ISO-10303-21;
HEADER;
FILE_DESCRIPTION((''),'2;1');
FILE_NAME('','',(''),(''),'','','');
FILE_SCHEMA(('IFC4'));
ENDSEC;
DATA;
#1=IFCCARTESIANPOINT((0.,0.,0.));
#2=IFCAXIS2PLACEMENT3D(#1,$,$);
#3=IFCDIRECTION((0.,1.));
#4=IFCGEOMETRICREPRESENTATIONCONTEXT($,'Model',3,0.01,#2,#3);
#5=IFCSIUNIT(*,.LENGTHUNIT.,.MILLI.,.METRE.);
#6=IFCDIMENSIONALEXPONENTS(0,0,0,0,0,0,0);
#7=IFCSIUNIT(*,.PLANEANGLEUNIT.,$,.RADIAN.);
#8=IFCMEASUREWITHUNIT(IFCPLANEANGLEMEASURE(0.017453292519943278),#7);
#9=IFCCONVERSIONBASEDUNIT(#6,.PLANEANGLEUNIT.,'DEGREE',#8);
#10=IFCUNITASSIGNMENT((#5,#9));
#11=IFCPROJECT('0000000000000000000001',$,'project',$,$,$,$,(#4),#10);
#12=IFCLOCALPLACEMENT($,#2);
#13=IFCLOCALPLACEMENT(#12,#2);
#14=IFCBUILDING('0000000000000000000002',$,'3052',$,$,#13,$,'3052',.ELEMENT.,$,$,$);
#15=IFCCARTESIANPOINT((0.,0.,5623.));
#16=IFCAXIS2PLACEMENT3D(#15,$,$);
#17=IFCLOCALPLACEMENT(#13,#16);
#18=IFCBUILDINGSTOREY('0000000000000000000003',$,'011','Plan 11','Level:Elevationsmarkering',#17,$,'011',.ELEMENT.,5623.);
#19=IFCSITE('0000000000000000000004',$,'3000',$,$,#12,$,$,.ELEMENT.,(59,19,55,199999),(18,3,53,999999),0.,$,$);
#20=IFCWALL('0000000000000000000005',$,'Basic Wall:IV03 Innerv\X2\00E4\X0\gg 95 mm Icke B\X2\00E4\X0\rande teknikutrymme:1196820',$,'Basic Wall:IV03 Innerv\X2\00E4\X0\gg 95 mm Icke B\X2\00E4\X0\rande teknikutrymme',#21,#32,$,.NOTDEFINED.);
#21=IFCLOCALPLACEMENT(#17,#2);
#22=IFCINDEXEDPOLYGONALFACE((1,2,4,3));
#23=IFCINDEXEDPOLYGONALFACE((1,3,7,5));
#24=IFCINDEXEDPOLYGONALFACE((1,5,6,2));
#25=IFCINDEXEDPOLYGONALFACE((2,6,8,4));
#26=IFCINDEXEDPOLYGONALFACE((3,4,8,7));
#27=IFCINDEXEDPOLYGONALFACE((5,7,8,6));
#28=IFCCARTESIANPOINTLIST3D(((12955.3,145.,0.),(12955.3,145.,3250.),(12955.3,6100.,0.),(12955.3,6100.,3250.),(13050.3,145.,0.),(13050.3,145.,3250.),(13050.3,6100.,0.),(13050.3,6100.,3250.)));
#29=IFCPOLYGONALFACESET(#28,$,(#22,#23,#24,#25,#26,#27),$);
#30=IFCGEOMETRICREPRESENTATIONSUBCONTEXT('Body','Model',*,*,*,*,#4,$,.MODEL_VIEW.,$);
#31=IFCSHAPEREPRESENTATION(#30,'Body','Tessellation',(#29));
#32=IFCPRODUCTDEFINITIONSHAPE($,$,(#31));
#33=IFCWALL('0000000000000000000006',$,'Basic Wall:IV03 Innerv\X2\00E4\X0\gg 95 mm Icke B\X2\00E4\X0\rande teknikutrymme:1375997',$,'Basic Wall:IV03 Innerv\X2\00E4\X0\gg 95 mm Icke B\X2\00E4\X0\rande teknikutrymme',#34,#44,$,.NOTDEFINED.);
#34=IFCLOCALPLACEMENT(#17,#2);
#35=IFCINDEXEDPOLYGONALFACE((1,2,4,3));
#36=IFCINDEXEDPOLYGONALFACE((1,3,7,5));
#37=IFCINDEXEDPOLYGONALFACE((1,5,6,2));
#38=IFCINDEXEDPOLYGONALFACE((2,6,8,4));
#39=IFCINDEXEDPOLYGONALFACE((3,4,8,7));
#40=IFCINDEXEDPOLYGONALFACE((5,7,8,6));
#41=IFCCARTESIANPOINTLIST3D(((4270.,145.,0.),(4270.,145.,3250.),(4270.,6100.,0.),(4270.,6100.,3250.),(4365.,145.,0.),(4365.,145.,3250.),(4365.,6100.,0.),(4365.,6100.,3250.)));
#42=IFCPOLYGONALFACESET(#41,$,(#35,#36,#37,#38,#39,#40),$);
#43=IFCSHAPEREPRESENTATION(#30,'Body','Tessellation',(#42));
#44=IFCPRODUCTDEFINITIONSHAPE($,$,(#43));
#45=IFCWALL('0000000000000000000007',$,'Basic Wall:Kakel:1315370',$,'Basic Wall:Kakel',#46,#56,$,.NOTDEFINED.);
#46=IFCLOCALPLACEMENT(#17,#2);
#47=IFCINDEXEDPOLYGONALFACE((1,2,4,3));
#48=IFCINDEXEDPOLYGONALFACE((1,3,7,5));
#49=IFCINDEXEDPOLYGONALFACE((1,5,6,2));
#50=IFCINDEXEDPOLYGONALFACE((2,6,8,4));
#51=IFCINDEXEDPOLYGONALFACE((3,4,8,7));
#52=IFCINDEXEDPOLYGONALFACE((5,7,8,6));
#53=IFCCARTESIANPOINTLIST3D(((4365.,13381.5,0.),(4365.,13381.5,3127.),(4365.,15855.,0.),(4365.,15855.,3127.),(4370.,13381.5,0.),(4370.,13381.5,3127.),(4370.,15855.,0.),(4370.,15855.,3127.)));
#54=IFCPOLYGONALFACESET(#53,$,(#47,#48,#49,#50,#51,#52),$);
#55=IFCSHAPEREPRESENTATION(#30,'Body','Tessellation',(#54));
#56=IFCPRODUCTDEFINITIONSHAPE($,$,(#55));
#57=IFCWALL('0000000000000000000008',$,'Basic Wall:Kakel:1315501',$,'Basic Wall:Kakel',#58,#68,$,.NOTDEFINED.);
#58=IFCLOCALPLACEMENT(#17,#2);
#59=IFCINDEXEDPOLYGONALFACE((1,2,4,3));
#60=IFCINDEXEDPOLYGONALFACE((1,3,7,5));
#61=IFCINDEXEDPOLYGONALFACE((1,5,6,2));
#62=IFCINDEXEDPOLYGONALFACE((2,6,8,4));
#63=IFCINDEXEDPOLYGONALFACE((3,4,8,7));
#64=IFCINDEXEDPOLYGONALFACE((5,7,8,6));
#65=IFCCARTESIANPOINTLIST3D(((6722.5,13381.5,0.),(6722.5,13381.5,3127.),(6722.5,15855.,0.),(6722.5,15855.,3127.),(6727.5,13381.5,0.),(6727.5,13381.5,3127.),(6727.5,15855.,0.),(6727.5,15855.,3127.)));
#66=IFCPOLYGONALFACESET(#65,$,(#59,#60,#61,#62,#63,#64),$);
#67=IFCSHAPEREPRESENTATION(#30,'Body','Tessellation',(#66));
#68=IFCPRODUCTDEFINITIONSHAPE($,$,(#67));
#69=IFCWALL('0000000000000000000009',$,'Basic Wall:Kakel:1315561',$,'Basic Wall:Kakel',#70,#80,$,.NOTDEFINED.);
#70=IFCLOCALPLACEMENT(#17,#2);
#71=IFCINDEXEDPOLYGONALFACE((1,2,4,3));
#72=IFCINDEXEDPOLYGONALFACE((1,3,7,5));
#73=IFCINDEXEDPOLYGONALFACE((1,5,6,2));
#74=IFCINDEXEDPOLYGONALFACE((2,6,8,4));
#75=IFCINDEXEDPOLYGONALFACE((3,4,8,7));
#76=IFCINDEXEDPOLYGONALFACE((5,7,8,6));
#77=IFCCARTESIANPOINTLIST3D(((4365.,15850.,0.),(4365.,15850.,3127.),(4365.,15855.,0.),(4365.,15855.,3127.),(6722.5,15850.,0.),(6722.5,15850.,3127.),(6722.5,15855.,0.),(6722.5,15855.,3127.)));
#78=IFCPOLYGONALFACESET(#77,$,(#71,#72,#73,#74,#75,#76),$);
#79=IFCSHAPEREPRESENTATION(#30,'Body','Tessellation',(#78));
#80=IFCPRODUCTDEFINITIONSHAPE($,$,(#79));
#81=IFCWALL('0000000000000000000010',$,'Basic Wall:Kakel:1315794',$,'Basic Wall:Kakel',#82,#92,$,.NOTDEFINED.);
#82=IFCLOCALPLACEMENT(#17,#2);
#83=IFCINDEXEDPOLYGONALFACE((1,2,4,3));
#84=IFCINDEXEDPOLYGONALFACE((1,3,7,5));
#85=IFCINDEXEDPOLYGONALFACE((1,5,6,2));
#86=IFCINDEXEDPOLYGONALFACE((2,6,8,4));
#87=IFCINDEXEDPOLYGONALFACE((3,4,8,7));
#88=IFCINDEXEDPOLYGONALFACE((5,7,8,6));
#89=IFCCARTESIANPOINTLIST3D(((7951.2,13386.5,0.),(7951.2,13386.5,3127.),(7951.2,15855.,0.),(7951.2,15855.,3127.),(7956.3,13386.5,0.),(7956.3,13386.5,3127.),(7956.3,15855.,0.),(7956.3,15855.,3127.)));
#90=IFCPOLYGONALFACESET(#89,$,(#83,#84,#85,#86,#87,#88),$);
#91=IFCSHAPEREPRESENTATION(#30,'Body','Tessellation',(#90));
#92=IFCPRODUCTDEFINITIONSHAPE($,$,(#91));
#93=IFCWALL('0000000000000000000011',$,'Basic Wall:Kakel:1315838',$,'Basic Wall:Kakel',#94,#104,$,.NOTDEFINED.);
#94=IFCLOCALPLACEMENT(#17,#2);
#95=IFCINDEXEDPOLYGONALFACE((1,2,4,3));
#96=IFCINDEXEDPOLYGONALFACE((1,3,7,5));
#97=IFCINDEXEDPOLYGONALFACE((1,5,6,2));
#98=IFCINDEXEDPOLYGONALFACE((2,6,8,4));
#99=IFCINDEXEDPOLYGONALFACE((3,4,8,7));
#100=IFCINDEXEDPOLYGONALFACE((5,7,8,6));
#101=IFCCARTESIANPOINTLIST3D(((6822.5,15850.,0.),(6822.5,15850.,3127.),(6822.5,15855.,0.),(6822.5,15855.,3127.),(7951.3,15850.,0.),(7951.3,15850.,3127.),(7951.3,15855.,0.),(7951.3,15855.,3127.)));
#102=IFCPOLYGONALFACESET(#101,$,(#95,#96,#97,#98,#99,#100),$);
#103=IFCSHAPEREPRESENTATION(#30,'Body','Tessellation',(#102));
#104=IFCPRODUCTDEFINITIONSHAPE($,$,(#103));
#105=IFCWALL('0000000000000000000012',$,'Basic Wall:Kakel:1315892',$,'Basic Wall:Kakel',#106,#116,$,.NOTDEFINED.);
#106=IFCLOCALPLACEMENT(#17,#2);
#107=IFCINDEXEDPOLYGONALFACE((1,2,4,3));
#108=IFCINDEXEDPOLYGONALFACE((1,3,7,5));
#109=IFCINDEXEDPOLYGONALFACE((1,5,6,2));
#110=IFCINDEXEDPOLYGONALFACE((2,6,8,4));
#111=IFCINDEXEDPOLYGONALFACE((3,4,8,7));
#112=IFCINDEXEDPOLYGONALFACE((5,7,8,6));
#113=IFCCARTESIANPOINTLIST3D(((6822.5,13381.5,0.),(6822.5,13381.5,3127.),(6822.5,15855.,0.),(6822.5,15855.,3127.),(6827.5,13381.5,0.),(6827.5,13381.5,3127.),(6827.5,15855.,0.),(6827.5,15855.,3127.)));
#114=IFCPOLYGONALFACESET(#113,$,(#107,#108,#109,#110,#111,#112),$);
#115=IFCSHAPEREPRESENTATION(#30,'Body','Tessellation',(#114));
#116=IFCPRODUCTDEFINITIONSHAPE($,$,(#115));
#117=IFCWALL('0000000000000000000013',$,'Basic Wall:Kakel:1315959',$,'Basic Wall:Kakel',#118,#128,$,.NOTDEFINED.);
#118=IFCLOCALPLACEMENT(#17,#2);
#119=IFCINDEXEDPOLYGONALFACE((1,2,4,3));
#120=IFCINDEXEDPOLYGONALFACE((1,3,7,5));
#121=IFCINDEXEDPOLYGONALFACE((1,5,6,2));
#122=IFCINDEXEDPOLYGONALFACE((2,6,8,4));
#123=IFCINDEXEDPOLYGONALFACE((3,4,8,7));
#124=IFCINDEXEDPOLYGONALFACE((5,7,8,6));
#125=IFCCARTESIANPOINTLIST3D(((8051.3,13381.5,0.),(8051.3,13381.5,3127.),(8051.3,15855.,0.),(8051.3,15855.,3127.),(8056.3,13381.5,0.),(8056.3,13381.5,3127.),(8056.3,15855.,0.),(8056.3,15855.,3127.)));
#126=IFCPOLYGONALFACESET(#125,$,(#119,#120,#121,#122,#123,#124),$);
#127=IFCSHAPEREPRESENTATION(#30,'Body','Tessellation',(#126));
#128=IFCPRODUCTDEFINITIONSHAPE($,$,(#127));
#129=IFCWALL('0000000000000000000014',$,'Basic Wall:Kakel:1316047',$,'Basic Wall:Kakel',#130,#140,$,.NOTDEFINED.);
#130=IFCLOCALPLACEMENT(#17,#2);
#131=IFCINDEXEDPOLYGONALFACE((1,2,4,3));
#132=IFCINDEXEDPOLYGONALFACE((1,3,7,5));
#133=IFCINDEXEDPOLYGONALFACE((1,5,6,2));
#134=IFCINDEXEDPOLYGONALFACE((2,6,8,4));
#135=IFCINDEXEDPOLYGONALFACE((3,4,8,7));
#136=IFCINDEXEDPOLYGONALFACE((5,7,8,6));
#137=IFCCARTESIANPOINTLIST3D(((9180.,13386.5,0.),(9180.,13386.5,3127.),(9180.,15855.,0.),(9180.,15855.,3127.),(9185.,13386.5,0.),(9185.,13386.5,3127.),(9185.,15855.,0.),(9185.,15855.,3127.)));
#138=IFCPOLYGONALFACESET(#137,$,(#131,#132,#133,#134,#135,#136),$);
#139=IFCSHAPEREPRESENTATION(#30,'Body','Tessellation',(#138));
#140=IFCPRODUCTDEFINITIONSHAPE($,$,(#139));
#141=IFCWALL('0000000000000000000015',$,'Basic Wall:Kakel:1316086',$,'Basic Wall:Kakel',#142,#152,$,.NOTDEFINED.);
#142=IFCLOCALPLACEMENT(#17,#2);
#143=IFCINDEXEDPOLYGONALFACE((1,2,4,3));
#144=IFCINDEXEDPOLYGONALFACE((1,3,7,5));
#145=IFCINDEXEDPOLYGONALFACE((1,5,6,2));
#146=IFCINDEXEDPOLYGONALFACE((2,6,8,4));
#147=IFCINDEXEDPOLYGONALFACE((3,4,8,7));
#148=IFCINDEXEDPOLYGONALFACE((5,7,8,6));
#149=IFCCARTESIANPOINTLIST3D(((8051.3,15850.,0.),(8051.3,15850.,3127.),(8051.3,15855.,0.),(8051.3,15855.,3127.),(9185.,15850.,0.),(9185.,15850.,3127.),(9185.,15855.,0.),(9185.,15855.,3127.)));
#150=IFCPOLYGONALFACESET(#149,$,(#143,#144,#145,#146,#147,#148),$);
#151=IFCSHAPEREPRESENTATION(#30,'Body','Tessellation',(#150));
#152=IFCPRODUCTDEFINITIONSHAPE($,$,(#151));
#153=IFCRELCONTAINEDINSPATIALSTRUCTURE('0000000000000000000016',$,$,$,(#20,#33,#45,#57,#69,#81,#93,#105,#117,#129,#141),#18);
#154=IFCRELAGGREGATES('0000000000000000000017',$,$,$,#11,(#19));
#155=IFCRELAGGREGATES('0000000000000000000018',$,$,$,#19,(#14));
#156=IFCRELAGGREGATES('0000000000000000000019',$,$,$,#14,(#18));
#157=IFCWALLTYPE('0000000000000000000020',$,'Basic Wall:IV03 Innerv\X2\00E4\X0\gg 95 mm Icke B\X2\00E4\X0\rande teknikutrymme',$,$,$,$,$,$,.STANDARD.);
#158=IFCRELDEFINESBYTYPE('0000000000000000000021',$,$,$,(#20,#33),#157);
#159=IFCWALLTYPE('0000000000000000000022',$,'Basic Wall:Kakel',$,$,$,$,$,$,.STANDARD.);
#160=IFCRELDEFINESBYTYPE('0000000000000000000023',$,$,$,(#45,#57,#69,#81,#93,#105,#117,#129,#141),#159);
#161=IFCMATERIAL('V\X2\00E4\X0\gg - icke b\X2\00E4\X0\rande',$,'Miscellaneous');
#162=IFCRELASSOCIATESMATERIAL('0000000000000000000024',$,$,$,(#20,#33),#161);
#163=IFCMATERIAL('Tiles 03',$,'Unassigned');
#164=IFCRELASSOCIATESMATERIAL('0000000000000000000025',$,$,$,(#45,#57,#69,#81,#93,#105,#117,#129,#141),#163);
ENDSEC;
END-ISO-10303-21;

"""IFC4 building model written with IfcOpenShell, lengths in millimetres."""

from ifc_helpers import new_model, entity, si_unit, converted_unit, direction, frame, origin, place, context, subcontext, project, spatial, indexed_curve, outline, extrude, material, type_object, element, save


model = new_model("IFC4")

# Units and contexts
model_context = context("Model", 3, precision=0.01, world=origin(), true_north=direction((0.0, 1.0)))
body_context = subcontext(model_context, "Body", "Model", "MODEL_VIEW")
ifc_project = project(units=[si_unit("LENGTHUNIT", "METRE", prefix="MILLI"), converted_unit("PLANEANGLEUNIT", "DEGREE", entity("IfcPlaneAngleMeasure", 0.017453292519943278), si_unit("PLANEANGLEUNIT", "RADIAN"), dimensions=[0, 0, 0, 0, 0, 0, 0])], contexts=[model_context])

# Site, building, storey
site_placement = place(None, origin())
site = spatial("IfcSite", under=ifc_project, at=site_placement, Name="3000", CompositionType="ELEMENT", RefLatitude=(59, 19, 55, 199999), RefLongitude=(18, 3, 53, 999999), RefElevation=0.0)
building_placement = place(site_placement, origin())
building = spatial("IfcBuilding", under=site, at=building_placement, Name="3052", LongName="3052", CompositionType="ELEMENT")
storey_placement = place(building_placement, frame((0.0, 0.0, 5623.0)))
storey = spatial("IfcBuildingStorey", under=building, at=storey_placement, Name="011", Description="Plan 11", ObjectType="Level:Elevationsmarkering", LongName="011", CompositionType="ELEMENT", Elevation=5623.0)

# Walls
ifc_material_1 = material(Name="Vägg - icke bärande", Category="Miscellaneous")
wall_type_1 = type_object("IfcWallType", Name="Basic Wall:IV03 Innervägg 95 mm Icke Bärande teknikutrymme", PredefinedType="STANDARD")
wall_1_placement = place(storey_placement, frame((13002.8, 6100.0, 0.0), z_axis=(0.0, 0.0, 1.0), x_axis=(0.0, -1.0, 0.0)))
element("IfcWall", 1, at=wall_1_placement, inside=storey, type_object=wall_type_1, material=ifc_material_1, Name="Basic Wall:IV03 Innervägg 95 mm Icke Bärande teknikutrymme:1196820", ObjectType="Basic Wall:IV03 Innervägg 95 mm Icke Bärande teknikutrymme", PredefinedType="NOTDEFINED", context=body_context, shape_type="SweptSolid", body=[
    extrude(outline(indexed_curve([(5955.0, 47.5), (0.0, 47.5), (0.0, -47.5), (5955.0, -47.5), (5955.0, 47.5)], self_intersect=False)), origin(), (0.0, 0.0, 1.0), 3250.0),
])
wall_2_placement = place(storey_placement, frame((4317.5, 6100.0, 0.0), z_axis=(0.0, 0.0, 1.0), x_axis=(0.0, -1.0, 0.0)))
element("IfcWall", 2, at=wall_2_placement, inside=storey, type_object=wall_type_1, material=ifc_material_1, Name="Basic Wall:IV03 Innervägg 95 mm Icke Bärande teknikutrymme:1375997", ObjectType="Basic Wall:IV03 Innervägg 95 mm Icke Bärande teknikutrymme", PredefinedType="NOTDEFINED", context=body_context, shape_type="SweptSolid", body=[
    extrude(outline(indexed_curve([(5955.0, 47.5), (0.0, 47.5), (0.0, -47.5), (5955.0, -47.5), (5955.0, 47.5)], self_intersect=False)), origin(), (0.0, 0.0, 1.0), 3250.0),
])
ifc_material_2 = material(Name="Tiles 03", Category="Unassigned")
wall_type_2 = type_object("IfcWallType", Name="Basic Wall:Kakel", PredefinedType="STANDARD")
wall_3_placement = place(storey_placement, frame((4367.5, 15855.0, 0.0), z_axis=(0.0, 0.0, 1.0), x_axis=(0.0, -1.0, 0.0)))
element("IfcWall", 3, at=wall_3_placement, inside=storey, type_object=wall_type_2, material=ifc_material_2, Name="Basic Wall:Kakel:1315370", ObjectType="Basic Wall:Kakel", PredefinedType="NOTDEFINED", context=body_context, shape_type="SweptSolid", body=[
    extrude(outline(indexed_curve([(2473.5, 2.5), (0.0, 2.5), (0.0, -2.5), (2473.5, -2.5), (2473.5, 2.5)], self_intersect=False)), origin(), (0.0, 0.0, 1.0), 3127.0),
])
wall_4_placement = place(storey_placement, frame((6725.0, 13381.5, 0.0), z_axis=(0.0, 0.0, 1.0), x_axis=(0.0, 1.0, 0.0)))
element("IfcWall", 4, at=wall_4_placement, inside=storey, type_object=wall_type_2, material=ifc_material_2, Name="Basic Wall:Kakel:1315501", ObjectType="Basic Wall:Kakel", PredefinedType="NOTDEFINED", context=body_context, shape_type="SweptSolid", body=[
    extrude(outline(indexed_curve([(2473.5, 2.5), (0.0, 2.5), (0.0, -2.5), (2473.5, -2.5), (2473.5, 2.5)], self_intersect=False)), origin(), (0.0, 0.0, 1.0), 3127.0),
])
wall_5_placement = place(storey_placement, frame((6722.5, 15852.5, 0.0), z_axis=(0.0, 0.0, 1.0), x_axis=(-1.0, 0.0, 0.0)))
element("IfcWall", 5, at=wall_5_placement, inside=storey, type_object=wall_type_2, material=ifc_material_2, Name="Basic Wall:Kakel:1315561", ObjectType="Basic Wall:Kakel", PredefinedType="NOTDEFINED", context=body_context, shape_type="SweptSolid", body=[
    extrude(outline(indexed_curve([(2357.5, 2.5), (0.0, 2.5), (0.0, -2.5), (2357.5, -2.5), (2357.5, 2.5)], self_intersect=False)), origin(), (0.0, 0.0, 1.0), 3127.0),
])
wall_6_placement = place(storey_placement, frame((7953.8, 13386.5, 0.0), z_axis=(0.0, 0.0, 1.0), x_axis=(0.0, 1.0, 0.0)))
element("IfcWall", 6, at=wall_6_placement, inside=storey, type_object=wall_type_2, material=ifc_material_2, Name="Basic Wall:Kakel:1315794", ObjectType="Basic Wall:Kakel", PredefinedType="NOTDEFINED", context=body_context, shape_type="SweptSolid", body=[
    extrude(outline(indexed_curve([(2468.5, 2.5), (0.0, 2.5), (0.0, -2.5), (2468.5, -2.5), (2468.5, 2.5)], self_intersect=False)), origin(), (0.0, 0.0, 1.0), 3127.0),
])
wall_7_placement = place(storey_placement, frame((7951.3, 15852.5, 0.0), z_axis=(0.0, 0.0, 1.0), x_axis=(-1.0, 0.0, 0.0)))
element("IfcWall", 7, at=wall_7_placement, inside=storey, type_object=wall_type_2, material=ifc_material_2, Name="Basic Wall:Kakel:1315838", ObjectType="Basic Wall:Kakel", PredefinedType="NOTDEFINED", context=body_context, shape_type="SweptSolid", body=[
    extrude(outline(indexed_curve([(1128.8, 2.5), (0.0, 2.5), (0.0, -2.5), (1128.8, -2.5), (1128.8, 2.5)], self_intersect=False)), origin(), (0.0, 0.0, 1.0), 3127.0),
])
for number, where, z_axis, x_axis, name in (
    (8, (6825.0, 15855.0, 0.0), (0.0, 0.0, 1.0), (0.0, -1.0, 0.0), "Basic Wall:Kakel:1315892"),
    (9, (8053.8, 15855.0, 0.0), (0.0, 0.0, 1.0), (0.0, -1.0, 0.0), "Basic Wall:Kakel:1315959"),
):
    element("IfcWall", number, at=place(storey_placement, frame(where, z_axis=z_axis, x_axis=x_axis)), inside=storey, type_object=wall_type_2, material=ifc_material_2, Name=name, ObjectType="Basic Wall:Kakel", PredefinedType="NOTDEFINED", context=body_context, shape_type="SweptSolid", body=[
        extrude(outline(indexed_curve([(2473.5, 2.5), (0.0, 2.5), (0.0, -2.5), (2473.5, -2.5), (2473.5, 2.5)], self_intersect=False)), origin(), (0.0, 0.0, 1.0), 3127.0),
    ])
wall_8_placement = place(storey_placement, frame((9182.5, 13386.5, 0.0), z_axis=(0.0, 0.0, 1.0), x_axis=(0.0, 1.0, 0.0)))
element("IfcWall", 10, at=wall_8_placement, inside=storey, type_object=wall_type_2, material=ifc_material_2, Name="Basic Wall:Kakel:1316047", ObjectType="Basic Wall:Kakel", PredefinedType="NOTDEFINED", context=body_context, shape_type="SweptSolid", body=[
    extrude(outline(indexed_curve([(2468.5, 2.5), (0.0, 2.5), (0.0, -2.5), (2468.5, -2.5), (2468.5, 2.5)], self_intersect=False)), origin(), (0.0, 0.0, 1.0), 3127.0),
])
wall_9_placement = place(storey_placement, frame((9185.0, 15852.5, 0.0), z_axis=(0.0, 0.0, 1.0), x_axis=(-1.0, 0.0, 0.0)))
element("IfcWall", 11, at=wall_9_placement, inside=storey, type_object=wall_type_2, material=ifc_material_2, Name="Basic Wall:Kakel:1316086", ObjectType="Basic Wall:Kakel", PredefinedType="NOTDEFINED", context=body_context, shape_type="SweptSolid", body=[
    extrude(outline(indexed_curve([(1133.7, 2.5), (0.0, 2.5), (0.0, -2.5), (1133.7, -2.5), (1133.7, 2.5)], self_intersect=False)), origin(), (0.0, 0.0, 1.0), 3127.0),
])

save(model, "model.ifc")
